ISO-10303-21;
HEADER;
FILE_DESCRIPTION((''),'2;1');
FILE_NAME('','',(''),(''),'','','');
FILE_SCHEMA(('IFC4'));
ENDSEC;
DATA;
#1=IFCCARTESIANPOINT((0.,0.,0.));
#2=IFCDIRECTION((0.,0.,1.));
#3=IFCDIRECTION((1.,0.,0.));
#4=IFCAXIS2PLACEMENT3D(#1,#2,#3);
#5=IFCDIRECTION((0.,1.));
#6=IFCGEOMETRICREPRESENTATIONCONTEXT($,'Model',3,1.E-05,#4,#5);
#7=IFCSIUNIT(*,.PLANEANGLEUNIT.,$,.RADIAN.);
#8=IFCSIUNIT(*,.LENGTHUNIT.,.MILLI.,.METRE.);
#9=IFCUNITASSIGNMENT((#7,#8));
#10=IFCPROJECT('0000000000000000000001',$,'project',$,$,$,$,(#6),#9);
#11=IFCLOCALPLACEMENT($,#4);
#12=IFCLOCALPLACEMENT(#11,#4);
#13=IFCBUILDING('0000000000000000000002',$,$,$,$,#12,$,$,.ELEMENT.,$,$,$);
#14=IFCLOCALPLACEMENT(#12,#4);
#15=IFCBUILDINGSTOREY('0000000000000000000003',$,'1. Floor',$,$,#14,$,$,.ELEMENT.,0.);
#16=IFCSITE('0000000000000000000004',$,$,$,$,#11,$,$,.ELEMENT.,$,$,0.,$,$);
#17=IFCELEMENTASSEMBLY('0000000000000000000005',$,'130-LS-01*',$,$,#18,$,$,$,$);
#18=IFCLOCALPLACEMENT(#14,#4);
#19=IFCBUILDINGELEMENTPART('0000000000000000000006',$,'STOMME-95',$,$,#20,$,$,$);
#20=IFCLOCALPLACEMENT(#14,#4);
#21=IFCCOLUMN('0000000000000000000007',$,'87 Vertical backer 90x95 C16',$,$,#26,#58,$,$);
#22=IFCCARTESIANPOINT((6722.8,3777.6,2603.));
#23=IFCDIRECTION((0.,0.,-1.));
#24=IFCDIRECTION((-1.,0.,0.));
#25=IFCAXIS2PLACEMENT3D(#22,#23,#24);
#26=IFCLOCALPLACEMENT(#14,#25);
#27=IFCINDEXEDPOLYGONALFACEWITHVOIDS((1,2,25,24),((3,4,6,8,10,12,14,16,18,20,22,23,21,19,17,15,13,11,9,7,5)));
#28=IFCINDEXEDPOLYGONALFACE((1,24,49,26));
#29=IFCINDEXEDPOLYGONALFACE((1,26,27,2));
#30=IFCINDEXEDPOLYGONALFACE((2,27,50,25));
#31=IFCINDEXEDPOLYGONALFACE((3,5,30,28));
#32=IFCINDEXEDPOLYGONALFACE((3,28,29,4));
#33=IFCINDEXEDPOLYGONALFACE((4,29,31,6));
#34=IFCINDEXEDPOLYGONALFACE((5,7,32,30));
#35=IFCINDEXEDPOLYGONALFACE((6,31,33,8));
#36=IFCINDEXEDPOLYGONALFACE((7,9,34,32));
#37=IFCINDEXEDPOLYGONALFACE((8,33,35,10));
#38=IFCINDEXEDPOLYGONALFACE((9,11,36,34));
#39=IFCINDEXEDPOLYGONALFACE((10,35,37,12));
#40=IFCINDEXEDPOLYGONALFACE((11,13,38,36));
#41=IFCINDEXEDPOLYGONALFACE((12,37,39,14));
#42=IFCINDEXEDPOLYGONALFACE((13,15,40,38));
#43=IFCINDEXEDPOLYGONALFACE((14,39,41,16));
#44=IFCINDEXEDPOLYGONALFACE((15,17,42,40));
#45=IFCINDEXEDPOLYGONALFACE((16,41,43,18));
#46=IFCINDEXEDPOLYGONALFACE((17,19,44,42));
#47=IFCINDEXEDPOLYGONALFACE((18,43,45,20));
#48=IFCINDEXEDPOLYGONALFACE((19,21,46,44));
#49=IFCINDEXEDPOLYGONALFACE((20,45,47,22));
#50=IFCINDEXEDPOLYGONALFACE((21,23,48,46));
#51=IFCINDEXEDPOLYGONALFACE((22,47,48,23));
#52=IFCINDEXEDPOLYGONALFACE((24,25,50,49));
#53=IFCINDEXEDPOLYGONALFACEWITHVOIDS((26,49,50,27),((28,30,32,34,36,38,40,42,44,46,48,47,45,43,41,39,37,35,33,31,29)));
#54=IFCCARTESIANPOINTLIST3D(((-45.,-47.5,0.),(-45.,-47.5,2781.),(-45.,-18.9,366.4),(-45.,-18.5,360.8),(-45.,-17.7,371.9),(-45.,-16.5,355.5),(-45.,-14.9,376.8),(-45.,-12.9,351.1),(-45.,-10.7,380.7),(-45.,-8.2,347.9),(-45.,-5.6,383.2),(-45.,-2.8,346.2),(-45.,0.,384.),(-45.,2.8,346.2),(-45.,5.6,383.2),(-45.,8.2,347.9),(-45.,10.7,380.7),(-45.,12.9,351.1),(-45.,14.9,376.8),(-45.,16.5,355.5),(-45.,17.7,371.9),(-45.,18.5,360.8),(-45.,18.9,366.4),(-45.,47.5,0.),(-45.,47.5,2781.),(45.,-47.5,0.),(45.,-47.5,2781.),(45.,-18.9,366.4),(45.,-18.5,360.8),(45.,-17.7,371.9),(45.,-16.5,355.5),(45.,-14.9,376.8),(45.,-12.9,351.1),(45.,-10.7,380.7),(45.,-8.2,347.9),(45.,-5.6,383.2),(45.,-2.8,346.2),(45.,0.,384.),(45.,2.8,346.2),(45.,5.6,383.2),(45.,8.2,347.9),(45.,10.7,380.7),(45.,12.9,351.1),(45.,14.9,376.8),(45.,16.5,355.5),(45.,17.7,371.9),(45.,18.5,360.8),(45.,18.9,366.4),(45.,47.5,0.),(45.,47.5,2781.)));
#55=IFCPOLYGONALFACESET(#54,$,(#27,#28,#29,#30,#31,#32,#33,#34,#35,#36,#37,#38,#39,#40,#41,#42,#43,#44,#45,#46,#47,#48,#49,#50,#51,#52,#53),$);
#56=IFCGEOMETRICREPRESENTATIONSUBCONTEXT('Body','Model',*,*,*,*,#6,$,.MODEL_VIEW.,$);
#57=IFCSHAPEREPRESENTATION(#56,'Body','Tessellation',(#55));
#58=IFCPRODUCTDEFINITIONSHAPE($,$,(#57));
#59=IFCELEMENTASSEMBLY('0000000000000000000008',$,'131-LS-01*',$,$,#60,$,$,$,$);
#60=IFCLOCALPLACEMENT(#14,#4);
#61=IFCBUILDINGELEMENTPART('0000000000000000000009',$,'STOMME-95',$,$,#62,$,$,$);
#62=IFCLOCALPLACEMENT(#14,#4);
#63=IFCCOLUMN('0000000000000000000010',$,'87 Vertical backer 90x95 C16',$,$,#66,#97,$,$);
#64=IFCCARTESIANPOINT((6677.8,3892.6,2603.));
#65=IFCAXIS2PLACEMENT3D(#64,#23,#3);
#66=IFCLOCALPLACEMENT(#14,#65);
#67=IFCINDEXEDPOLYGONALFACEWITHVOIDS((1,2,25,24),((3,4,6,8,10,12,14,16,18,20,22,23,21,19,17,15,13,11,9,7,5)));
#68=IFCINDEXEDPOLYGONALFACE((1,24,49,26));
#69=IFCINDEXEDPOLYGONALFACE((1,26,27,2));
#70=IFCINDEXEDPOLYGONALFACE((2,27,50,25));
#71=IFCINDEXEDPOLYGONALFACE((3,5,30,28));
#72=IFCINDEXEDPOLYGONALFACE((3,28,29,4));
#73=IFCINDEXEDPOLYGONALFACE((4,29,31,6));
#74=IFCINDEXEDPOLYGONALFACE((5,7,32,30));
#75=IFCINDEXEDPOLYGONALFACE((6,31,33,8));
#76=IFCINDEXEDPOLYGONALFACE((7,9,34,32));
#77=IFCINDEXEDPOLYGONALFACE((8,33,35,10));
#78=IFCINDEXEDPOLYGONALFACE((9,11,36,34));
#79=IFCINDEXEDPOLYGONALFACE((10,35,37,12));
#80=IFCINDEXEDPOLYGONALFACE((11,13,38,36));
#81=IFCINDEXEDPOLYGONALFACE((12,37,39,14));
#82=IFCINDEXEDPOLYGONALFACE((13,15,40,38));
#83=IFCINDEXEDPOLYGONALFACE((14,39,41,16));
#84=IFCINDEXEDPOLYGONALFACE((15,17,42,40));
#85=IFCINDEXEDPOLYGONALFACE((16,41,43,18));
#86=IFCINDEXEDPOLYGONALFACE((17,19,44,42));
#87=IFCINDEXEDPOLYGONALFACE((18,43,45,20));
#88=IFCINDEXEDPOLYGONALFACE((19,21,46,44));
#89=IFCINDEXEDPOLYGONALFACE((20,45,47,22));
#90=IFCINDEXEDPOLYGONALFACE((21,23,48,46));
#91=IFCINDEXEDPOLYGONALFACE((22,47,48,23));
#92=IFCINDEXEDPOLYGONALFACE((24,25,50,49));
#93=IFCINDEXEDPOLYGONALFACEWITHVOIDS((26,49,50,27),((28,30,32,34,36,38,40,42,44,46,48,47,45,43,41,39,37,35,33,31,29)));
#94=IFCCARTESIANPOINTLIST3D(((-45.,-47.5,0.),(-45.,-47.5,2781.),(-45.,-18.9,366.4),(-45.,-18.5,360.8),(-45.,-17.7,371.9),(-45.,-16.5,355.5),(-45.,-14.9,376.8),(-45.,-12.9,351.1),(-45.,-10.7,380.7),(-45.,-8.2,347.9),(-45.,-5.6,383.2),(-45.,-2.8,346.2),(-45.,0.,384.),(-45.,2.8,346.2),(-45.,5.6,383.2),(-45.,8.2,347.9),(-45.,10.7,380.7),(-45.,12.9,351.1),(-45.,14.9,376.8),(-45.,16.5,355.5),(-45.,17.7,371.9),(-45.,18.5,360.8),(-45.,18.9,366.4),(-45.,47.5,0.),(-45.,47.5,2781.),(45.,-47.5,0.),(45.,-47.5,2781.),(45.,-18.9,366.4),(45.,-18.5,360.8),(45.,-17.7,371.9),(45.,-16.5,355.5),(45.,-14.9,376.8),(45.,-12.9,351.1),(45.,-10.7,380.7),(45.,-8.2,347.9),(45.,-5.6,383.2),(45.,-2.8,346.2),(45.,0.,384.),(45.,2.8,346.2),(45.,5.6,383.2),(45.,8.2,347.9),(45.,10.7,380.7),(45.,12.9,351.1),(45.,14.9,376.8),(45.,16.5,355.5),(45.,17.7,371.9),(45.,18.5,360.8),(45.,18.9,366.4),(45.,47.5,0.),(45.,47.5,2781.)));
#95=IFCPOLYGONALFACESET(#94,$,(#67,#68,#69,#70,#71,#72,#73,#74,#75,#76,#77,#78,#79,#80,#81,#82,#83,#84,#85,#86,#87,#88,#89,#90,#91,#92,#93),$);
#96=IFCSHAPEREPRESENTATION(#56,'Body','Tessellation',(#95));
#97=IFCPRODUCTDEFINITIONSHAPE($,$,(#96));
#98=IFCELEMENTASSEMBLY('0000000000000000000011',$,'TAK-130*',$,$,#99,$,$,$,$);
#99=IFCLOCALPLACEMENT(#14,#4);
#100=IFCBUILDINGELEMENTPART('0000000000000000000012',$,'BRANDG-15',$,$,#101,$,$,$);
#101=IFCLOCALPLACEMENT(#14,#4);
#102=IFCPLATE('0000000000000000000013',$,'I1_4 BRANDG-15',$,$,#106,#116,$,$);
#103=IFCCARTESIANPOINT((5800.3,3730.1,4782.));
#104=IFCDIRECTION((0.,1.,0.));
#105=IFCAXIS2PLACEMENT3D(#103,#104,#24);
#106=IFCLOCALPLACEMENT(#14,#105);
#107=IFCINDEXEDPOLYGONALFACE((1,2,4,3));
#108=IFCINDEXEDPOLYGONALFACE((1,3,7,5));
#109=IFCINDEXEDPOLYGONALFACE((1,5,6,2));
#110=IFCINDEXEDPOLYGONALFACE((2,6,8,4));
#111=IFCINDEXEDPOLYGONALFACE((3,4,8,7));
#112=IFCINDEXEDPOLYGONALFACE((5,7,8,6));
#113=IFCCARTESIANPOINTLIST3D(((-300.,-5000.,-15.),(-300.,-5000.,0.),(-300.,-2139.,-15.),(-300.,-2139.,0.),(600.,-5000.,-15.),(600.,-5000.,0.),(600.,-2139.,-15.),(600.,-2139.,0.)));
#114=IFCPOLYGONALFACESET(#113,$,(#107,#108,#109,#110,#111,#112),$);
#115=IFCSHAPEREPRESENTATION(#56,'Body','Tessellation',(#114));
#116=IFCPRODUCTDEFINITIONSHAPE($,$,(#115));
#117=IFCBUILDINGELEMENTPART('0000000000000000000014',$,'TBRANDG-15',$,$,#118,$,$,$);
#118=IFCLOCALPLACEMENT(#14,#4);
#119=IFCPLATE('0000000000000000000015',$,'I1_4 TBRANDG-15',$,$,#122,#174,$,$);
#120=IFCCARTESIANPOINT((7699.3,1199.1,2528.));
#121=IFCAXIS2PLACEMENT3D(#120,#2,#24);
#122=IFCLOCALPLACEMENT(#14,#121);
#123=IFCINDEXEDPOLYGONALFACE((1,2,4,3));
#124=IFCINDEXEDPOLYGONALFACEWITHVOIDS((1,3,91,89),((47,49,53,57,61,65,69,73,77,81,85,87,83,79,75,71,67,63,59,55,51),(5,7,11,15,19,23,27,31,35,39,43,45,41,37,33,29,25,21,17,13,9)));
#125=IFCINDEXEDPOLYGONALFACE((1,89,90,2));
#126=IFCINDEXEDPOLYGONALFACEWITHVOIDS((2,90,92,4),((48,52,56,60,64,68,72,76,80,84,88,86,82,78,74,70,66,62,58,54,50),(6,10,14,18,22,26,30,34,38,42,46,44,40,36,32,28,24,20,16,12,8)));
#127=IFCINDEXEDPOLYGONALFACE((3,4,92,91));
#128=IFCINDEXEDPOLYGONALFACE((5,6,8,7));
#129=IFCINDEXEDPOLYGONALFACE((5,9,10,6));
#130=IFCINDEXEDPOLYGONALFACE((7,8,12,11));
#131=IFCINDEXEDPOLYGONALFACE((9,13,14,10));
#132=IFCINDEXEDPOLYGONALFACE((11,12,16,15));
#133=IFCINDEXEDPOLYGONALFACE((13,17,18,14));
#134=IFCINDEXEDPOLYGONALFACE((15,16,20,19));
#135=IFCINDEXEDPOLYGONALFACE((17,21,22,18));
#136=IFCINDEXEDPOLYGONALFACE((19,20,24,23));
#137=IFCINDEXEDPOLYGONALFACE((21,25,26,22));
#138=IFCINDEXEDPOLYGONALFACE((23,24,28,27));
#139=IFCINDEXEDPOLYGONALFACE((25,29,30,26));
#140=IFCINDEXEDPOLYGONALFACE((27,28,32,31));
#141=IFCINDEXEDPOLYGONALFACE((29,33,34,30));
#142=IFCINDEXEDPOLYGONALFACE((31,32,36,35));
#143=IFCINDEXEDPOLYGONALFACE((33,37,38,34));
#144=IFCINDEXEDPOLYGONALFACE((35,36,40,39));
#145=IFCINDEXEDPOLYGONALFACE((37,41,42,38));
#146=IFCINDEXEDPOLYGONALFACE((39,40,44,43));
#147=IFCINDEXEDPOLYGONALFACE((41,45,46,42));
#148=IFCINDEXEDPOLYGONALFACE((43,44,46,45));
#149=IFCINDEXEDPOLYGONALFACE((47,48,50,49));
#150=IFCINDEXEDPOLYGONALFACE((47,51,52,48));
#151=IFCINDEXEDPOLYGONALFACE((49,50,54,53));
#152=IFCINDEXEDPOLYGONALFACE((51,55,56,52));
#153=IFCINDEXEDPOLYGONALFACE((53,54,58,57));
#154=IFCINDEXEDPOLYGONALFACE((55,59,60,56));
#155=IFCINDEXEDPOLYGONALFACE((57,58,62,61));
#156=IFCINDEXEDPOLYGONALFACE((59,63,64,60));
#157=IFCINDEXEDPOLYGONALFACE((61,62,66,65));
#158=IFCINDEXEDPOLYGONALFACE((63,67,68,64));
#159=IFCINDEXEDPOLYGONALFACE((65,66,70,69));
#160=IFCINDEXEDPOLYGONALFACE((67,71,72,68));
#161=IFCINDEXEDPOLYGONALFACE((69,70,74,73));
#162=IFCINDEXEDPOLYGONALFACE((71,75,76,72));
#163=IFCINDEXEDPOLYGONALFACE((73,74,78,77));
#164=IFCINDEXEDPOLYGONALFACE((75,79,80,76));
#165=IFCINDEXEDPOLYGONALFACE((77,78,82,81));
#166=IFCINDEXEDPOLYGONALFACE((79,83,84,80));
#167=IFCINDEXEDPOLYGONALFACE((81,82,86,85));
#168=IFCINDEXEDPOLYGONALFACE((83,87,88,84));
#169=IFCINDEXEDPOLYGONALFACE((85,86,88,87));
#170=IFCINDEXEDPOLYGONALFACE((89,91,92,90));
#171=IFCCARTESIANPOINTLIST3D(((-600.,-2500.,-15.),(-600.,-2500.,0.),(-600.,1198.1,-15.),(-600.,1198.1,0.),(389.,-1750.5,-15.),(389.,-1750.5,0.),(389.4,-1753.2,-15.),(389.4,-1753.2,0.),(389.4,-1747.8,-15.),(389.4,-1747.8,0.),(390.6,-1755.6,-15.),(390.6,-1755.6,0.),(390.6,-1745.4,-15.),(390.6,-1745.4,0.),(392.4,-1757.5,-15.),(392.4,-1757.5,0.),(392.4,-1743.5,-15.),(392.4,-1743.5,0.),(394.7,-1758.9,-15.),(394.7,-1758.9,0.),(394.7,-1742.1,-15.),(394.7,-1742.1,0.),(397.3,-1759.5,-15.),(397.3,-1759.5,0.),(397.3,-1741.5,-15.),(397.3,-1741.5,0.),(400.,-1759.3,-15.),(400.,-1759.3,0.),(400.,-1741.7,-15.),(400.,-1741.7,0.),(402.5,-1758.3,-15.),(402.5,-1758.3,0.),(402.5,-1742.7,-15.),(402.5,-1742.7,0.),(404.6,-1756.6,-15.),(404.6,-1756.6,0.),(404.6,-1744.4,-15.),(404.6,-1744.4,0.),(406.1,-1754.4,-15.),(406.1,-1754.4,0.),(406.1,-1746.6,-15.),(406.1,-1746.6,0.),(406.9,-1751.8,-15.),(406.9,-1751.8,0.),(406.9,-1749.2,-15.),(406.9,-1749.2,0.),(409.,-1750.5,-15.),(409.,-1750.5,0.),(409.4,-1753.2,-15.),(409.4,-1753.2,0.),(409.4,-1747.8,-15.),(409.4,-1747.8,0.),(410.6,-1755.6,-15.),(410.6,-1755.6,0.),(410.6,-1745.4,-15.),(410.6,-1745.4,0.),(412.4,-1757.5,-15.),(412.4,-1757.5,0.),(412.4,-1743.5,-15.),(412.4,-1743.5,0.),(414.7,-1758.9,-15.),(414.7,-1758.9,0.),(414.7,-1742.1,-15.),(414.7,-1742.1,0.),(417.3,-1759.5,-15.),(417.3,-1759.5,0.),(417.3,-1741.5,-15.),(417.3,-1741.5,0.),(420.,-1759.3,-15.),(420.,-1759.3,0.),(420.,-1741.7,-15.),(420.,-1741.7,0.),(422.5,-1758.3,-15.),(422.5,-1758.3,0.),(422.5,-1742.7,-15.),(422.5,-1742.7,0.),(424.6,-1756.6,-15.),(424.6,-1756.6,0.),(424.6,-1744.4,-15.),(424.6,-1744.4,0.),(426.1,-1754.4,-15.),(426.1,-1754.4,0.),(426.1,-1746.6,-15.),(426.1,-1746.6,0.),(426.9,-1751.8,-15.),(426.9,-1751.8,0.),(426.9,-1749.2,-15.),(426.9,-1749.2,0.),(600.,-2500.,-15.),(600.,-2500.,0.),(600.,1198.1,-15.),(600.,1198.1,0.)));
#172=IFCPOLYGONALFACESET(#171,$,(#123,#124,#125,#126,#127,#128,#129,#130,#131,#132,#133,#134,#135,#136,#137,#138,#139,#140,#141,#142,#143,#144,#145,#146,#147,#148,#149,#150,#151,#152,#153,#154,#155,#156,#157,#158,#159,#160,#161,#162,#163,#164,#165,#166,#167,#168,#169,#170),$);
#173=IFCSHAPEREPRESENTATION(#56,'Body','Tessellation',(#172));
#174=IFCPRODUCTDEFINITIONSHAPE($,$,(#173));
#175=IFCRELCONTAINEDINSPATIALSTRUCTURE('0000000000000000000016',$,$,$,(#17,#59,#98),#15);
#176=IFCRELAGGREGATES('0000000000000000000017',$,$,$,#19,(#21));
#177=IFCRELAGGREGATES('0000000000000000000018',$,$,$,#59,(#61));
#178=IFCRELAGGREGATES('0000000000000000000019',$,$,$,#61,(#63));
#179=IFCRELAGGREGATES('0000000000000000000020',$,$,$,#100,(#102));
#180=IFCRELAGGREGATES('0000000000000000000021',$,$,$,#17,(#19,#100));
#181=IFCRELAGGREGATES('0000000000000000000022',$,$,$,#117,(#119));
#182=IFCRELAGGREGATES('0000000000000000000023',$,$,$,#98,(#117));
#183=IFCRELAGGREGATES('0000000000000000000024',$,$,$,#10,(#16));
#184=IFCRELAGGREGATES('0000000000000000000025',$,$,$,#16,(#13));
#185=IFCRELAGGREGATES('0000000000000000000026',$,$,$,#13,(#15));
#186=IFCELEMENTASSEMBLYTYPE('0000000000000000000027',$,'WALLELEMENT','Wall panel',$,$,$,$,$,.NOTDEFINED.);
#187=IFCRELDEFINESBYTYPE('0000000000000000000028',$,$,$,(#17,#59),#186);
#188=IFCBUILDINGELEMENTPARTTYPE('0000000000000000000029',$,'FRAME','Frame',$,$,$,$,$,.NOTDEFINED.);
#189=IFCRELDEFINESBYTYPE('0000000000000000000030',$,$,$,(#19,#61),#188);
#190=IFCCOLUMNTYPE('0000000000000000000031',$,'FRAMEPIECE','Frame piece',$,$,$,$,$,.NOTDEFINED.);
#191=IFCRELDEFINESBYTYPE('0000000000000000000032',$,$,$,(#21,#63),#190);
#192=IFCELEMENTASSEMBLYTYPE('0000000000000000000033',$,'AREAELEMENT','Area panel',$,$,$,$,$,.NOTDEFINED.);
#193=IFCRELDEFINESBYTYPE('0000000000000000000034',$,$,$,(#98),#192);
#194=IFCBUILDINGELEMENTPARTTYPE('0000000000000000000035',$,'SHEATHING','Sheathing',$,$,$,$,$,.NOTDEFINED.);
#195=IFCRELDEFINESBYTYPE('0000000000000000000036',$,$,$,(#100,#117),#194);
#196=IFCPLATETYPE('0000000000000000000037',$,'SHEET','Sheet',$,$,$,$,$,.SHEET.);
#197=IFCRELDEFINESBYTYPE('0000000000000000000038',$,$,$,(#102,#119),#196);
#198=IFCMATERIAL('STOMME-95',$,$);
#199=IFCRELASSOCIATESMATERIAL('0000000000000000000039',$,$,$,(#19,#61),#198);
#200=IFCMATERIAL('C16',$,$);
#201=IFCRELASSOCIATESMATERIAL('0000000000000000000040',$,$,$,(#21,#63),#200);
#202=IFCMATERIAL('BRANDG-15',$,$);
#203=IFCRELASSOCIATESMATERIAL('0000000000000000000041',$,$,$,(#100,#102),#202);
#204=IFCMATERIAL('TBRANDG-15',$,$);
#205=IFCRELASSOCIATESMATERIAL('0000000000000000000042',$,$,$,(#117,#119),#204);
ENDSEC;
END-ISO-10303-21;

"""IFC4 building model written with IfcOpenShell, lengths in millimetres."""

from ifc_helpers import new_model, si_unit, direction, frame, origin_with_axes, origin_2d_with_axis, place, context, subcontext, project, spatial, rectangle, circle, extrude, boolean, material, type_object, element, aggregate, save


model = new_model("IFC4")

# Units and contexts
model_context = context("Model", 3, precision=1e-05, world=origin_with_axes(), true_north=direction((0.0, 1.0)))
body_context = subcontext(model_context, "Body", "Model", "MODEL_VIEW")
ifc_project = project(units=[si_unit("PLANEANGLEUNIT", "RADIAN"), si_unit("LENGTHUNIT", "METRE", prefix="MILLI")], contexts=[model_context])

# Site, building, storey
site_placement = place(None, origin_with_axes())
site = spatial("IfcSite", under=ifc_project, at=site_placement, CompositionType="ELEMENT", RefElevation=0.0)
building_placement = place(site_placement, origin_with_axes())
building = spatial("IfcBuilding", under=site, at=building_placement, CompositionType="ELEMENT")
storey_placement = place(building_placement, origin_with_axes())
storey = spatial("IfcBuildingStorey", under=building, at=storey_placement, Name="1. Floor", CompositionType="ELEMENT", Elevation=0.0)

# Element assemblies, building element parts, columns
element_assembly_type_1 = type_object("IfcElementAssemblyType", Name="WALLELEMENT", Description="Wall panel", PredefinedType="NOTDEFINED")
assembly_1_placement = place(storey_placement, origin_with_axes())
assembly_1 = element("IfcElementAssembly", 1, at=assembly_1_placement, inside=storey, type_object=element_assembly_type_1, Name="130-LS-01*")
ifc_material_1 = material(Name="STOMME-95")
building_element_part_type_1 = type_object("IfcBuildingElementPartType", Name="FRAME", Description="Frame", PredefinedType="NOTDEFINED")
building_element_part_1_placement = place(storey_placement, origin_with_axes())
building_element_part_1 = element("IfcBuildingElementPart", 2, at=building_element_part_1_placement, type_object=building_element_part_type_1, material=ifc_material_1, Name="STOMME-95")
ifc_material_2 = material(Name="C16")
column_type = type_object("IfcColumnType", Name="FRAMEPIECE", Description="Frame piece", PredefinedType="NOTDEFINED")
column_1_placement = place(storey_placement, frame((6722.8, 3777.6, 2603.0), z_axis=(0.0, 0.0, -1.0), x_axis=(-1.0, 0.0, 0.0)))
column_1 = element("IfcColumn", 3, at=column_1_placement, type_object=column_type, material=ifc_material_2, Name="87 Vertical backer 90x95 C16", context=body_context, shape_type="CSG", body=[
    boolean("DIFFERENCE", boolean("DIFFERENCE", extrude(rectangle(XDim=90.0, YDim=95.0, at=origin_2d_with_axis()), origin_with_axes(), (0.0, 0.0, 1.0), 2781.0), extrude(circle(Radius=19.0, at=origin_2d_with_axis()), frame((90.0, 0.0, 365.0), z_axis=(1.0, 0.0, 0.0), x_axis=(0.0, 0.0, 1.0)), (0.0, 0.0, -1.0), 180.0)), extrude(circle(Radius=19.0, at=origin_2d_with_axis()), frame((-90.0, 0.0, 365.0), z_axis=(-1.0, 0.0, 0.0), x_axis=(0.0, 0.0, 1.0)), (0.0, 0.0, -1.0), 180.0)),
])
aggregate(building_element_part_1, [column_1])
assembly_2_placement = place(storey_placement, origin_with_axes())
assembly_2 = element("IfcElementAssembly", 4, at=assembly_2_placement, inside=storey, type_object=element_assembly_type_1, Name="131-LS-01*")
building_element_part_2_placement = place(storey_placement, origin_with_axes())
building_element_part_2 = element("IfcBuildingElementPart", 5, at=building_element_part_2_placement, type_object=building_element_part_type_1, material=ifc_material_1, Name="STOMME-95")
aggregate(assembly_2, [building_element_part_2])
column_2_placement = place(storey_placement, frame((6677.8, 3892.6, 2603.0), z_axis=(0.0, 0.0, -1.0), x_axis=(1.0, 0.0, 0.0)))
column_2 = element("IfcColumn", 6, at=column_2_placement, type_object=column_type, material=ifc_material_2, Name="87 Vertical backer 90x95 C16", context=body_context, shape_type="CSG", body=[
    boolean("DIFFERENCE", boolean("DIFFERENCE", extrude(rectangle(XDim=90.0, YDim=95.0, at=origin_2d_with_axis()), origin_with_axes(), (0.0, 0.0, 1.0), 2781.0), extrude(circle(Radius=19.0, at=origin_2d_with_axis()), frame((90.0, 0.0, 365.0), z_axis=(1.0, 0.0, 0.0), x_axis=(0.0, 0.0, 1.0)), (0.0, 0.0, -1.0), 180.0)), extrude(circle(Radius=19.0, at=origin_2d_with_axis()), frame((-90.0, 0.0, 365.0), z_axis=(-1.0, 0.0, 0.0), x_axis=(0.0, 0.0, 1.0)), (0.0, 0.0, -1.0), 180.0)),
])
aggregate(building_element_part_2, [column_2])

# Element assembly
element_assembly_type_2 = type_object("IfcElementAssemblyType", Name="AREAELEMENT", Description="Area panel", PredefinedType="NOTDEFINED")
assembly_3_placement = place(storey_placement, origin_with_axes())
assembly_3 = element("IfcElementAssembly", 7, at=assembly_3_placement, inside=storey, type_object=element_assembly_type_2, Name="TAK-130*")

# Building element part, plate
ifc_material_3 = material(Name="BRANDG-15")
building_element_part_type_2 = type_object("IfcBuildingElementPartType", Name="SHEATHING", Description="Sheathing", PredefinedType="NOTDEFINED")
building_element_part_3_placement = place(storey_placement, origin_with_axes())
building_element_part_3 = element("IfcBuildingElementPart", 8, at=building_element_part_3_placement, type_object=building_element_part_type_2, material=ifc_material_3, Name="BRANDG-15")
plate_type = type_object("IfcPlateType", Name="SHEET", Description="Sheet", PredefinedType="SHEET")
plate_1_placement = place(storey_placement, frame((5800.3, 3730.1, 4782.0), z_axis=(0.0, 1.0, 0.0), x_axis=(-1.0, 0.0, 0.0)))
plate_1 = element("IfcPlate", 9, at=plate_1_placement, type_object=plate_type, material=ifc_material_3, Name="I1_4 BRANDG-15", context=body_context, shape_type="SweptSolid", body=[
    extrude(rectangle(XDim=15.0, YDim=900.0, at=origin_2d_with_axis()), frame((150.0, -5000.0, -7.5), z_axis=(0.0, 1.0, 0.0), x_axis=(0.0, 0.0, 1.0)), (0.0, 0.0, 1.0), 2861.0),
])
aggregate(building_element_part_3, [plate_1])

aggregate(assembly_1, [building_element_part_1, building_element_part_3])

# Building element part, plate
ifc_material_4 = material(Name="TBRANDG-15")
building_element_part_4_placement = place(storey_placement, origin_with_axes())
building_element_part_4 = element("IfcBuildingElementPart", 10, at=building_element_part_4_placement, type_object=building_element_part_type_2, material=ifc_material_4, Name="TBRANDG-15")
plate_2_placement = place(storey_placement, frame((7699.3, 1199.1, 2528.0), z_axis=(0.0, 0.0, 1.0), x_axis=(-1.0, 0.0, 0.0)))
plate_2 = element("IfcPlate", 11, at=plate_2_placement, type_object=plate_type, material=ifc_material_4, Name="I1_4 TBRANDG-15", context=body_context, shape_type="CSG", body=[
    boolean("DIFFERENCE", boolean("DIFFERENCE", boolean("DIFFERENCE", boolean("DIFFERENCE", boolean("DIFFERENCE", boolean("DIFFERENCE", boolean("DIFFERENCE", boolean("DIFFERENCE", extrude(rectangle(XDim=15.0, YDim=1200.0, at=origin_2d_with_axis()), frame((0.0, -2500.0, -7.5), z_axis=(0.0, 1.0, 0.0), x_axis=(0.0, 0.0, 1.0)), (0.0, 0.0, 1.0), 3698.1), extrude(circle(Radius=9.0, at=origin_2d_with_axis()), frame((418.0, -1750.5, 10.0), z_axis=(0.0, 0.0, 1.0), x_axis=(-1.0, 0.0, 0.0)), (0.0, 0.0, -1.0), 50.0)), extrude(circle(Radius=9.0, at=origin_2d_with_axis()), frame((398.0, -1750.5, 10.0), z_axis=(0.0, 0.0, 1.0), x_axis=(-1.0, 0.0, 0.0)), (0.0, 0.0, -1.0), 50.0)), extrude(circle(Radius=9.0, at=origin_2d_with_axis()), frame((418.0, -1750.5, 10.0), z_axis=(0.0, 0.0, 1.0), x_axis=(-1.0, 0.0, 0.0)), (0.0, 0.0, -1.0), 50.0)), extrude(circle(Radius=9.0, at=origin_2d_with_axis()), frame((398.0, -1750.5, 10.0), z_axis=(0.0, 0.0, 1.0), x_axis=(-1.0, 0.0, 0.0)), (0.0, 0.0, -1.0), 50.0)), extrude(circle(Radius=9.0, at=origin_2d_with_axis()), frame((418.0, -1750.5, 10.0), z_axis=(0.0, 0.0, 1.0), x_axis=(-1.0, 0.0, 0.0)), (0.0, 0.0, -1.0), 50.0)), extrude(circle(Radius=9.0, at=origin_2d_with_axis()), frame((398.0, -1750.5, 10.0), z_axis=(0.0, 0.0, 1.0), x_axis=(-1.0, 0.0, 0.0)), (0.0, 0.0, -1.0), 50.0)), extrude(circle(Radius=9.0, at=origin_2d_with_axis()), frame((418.0, -1750.5, 10.0), z_axis=(0.0, 0.0, 1.0), x_axis=(-1.0, 0.0, 0.0)), (0.0, 0.0, -1.0), 50.0)), extrude(circle(Radius=9.0, at=origin_2d_with_axis()), frame((398.0, -1750.5, 10.0), z_axis=(0.0, 0.0, 1.0), x_axis=(-1.0, 0.0, 0.0)), (0.0, 0.0, -1.0), 50.0)),
])
aggregate(building_element_part_4, [plate_2])

aggregate(assembly_3, [building_element_part_4])

save(model, "model.ifc")
